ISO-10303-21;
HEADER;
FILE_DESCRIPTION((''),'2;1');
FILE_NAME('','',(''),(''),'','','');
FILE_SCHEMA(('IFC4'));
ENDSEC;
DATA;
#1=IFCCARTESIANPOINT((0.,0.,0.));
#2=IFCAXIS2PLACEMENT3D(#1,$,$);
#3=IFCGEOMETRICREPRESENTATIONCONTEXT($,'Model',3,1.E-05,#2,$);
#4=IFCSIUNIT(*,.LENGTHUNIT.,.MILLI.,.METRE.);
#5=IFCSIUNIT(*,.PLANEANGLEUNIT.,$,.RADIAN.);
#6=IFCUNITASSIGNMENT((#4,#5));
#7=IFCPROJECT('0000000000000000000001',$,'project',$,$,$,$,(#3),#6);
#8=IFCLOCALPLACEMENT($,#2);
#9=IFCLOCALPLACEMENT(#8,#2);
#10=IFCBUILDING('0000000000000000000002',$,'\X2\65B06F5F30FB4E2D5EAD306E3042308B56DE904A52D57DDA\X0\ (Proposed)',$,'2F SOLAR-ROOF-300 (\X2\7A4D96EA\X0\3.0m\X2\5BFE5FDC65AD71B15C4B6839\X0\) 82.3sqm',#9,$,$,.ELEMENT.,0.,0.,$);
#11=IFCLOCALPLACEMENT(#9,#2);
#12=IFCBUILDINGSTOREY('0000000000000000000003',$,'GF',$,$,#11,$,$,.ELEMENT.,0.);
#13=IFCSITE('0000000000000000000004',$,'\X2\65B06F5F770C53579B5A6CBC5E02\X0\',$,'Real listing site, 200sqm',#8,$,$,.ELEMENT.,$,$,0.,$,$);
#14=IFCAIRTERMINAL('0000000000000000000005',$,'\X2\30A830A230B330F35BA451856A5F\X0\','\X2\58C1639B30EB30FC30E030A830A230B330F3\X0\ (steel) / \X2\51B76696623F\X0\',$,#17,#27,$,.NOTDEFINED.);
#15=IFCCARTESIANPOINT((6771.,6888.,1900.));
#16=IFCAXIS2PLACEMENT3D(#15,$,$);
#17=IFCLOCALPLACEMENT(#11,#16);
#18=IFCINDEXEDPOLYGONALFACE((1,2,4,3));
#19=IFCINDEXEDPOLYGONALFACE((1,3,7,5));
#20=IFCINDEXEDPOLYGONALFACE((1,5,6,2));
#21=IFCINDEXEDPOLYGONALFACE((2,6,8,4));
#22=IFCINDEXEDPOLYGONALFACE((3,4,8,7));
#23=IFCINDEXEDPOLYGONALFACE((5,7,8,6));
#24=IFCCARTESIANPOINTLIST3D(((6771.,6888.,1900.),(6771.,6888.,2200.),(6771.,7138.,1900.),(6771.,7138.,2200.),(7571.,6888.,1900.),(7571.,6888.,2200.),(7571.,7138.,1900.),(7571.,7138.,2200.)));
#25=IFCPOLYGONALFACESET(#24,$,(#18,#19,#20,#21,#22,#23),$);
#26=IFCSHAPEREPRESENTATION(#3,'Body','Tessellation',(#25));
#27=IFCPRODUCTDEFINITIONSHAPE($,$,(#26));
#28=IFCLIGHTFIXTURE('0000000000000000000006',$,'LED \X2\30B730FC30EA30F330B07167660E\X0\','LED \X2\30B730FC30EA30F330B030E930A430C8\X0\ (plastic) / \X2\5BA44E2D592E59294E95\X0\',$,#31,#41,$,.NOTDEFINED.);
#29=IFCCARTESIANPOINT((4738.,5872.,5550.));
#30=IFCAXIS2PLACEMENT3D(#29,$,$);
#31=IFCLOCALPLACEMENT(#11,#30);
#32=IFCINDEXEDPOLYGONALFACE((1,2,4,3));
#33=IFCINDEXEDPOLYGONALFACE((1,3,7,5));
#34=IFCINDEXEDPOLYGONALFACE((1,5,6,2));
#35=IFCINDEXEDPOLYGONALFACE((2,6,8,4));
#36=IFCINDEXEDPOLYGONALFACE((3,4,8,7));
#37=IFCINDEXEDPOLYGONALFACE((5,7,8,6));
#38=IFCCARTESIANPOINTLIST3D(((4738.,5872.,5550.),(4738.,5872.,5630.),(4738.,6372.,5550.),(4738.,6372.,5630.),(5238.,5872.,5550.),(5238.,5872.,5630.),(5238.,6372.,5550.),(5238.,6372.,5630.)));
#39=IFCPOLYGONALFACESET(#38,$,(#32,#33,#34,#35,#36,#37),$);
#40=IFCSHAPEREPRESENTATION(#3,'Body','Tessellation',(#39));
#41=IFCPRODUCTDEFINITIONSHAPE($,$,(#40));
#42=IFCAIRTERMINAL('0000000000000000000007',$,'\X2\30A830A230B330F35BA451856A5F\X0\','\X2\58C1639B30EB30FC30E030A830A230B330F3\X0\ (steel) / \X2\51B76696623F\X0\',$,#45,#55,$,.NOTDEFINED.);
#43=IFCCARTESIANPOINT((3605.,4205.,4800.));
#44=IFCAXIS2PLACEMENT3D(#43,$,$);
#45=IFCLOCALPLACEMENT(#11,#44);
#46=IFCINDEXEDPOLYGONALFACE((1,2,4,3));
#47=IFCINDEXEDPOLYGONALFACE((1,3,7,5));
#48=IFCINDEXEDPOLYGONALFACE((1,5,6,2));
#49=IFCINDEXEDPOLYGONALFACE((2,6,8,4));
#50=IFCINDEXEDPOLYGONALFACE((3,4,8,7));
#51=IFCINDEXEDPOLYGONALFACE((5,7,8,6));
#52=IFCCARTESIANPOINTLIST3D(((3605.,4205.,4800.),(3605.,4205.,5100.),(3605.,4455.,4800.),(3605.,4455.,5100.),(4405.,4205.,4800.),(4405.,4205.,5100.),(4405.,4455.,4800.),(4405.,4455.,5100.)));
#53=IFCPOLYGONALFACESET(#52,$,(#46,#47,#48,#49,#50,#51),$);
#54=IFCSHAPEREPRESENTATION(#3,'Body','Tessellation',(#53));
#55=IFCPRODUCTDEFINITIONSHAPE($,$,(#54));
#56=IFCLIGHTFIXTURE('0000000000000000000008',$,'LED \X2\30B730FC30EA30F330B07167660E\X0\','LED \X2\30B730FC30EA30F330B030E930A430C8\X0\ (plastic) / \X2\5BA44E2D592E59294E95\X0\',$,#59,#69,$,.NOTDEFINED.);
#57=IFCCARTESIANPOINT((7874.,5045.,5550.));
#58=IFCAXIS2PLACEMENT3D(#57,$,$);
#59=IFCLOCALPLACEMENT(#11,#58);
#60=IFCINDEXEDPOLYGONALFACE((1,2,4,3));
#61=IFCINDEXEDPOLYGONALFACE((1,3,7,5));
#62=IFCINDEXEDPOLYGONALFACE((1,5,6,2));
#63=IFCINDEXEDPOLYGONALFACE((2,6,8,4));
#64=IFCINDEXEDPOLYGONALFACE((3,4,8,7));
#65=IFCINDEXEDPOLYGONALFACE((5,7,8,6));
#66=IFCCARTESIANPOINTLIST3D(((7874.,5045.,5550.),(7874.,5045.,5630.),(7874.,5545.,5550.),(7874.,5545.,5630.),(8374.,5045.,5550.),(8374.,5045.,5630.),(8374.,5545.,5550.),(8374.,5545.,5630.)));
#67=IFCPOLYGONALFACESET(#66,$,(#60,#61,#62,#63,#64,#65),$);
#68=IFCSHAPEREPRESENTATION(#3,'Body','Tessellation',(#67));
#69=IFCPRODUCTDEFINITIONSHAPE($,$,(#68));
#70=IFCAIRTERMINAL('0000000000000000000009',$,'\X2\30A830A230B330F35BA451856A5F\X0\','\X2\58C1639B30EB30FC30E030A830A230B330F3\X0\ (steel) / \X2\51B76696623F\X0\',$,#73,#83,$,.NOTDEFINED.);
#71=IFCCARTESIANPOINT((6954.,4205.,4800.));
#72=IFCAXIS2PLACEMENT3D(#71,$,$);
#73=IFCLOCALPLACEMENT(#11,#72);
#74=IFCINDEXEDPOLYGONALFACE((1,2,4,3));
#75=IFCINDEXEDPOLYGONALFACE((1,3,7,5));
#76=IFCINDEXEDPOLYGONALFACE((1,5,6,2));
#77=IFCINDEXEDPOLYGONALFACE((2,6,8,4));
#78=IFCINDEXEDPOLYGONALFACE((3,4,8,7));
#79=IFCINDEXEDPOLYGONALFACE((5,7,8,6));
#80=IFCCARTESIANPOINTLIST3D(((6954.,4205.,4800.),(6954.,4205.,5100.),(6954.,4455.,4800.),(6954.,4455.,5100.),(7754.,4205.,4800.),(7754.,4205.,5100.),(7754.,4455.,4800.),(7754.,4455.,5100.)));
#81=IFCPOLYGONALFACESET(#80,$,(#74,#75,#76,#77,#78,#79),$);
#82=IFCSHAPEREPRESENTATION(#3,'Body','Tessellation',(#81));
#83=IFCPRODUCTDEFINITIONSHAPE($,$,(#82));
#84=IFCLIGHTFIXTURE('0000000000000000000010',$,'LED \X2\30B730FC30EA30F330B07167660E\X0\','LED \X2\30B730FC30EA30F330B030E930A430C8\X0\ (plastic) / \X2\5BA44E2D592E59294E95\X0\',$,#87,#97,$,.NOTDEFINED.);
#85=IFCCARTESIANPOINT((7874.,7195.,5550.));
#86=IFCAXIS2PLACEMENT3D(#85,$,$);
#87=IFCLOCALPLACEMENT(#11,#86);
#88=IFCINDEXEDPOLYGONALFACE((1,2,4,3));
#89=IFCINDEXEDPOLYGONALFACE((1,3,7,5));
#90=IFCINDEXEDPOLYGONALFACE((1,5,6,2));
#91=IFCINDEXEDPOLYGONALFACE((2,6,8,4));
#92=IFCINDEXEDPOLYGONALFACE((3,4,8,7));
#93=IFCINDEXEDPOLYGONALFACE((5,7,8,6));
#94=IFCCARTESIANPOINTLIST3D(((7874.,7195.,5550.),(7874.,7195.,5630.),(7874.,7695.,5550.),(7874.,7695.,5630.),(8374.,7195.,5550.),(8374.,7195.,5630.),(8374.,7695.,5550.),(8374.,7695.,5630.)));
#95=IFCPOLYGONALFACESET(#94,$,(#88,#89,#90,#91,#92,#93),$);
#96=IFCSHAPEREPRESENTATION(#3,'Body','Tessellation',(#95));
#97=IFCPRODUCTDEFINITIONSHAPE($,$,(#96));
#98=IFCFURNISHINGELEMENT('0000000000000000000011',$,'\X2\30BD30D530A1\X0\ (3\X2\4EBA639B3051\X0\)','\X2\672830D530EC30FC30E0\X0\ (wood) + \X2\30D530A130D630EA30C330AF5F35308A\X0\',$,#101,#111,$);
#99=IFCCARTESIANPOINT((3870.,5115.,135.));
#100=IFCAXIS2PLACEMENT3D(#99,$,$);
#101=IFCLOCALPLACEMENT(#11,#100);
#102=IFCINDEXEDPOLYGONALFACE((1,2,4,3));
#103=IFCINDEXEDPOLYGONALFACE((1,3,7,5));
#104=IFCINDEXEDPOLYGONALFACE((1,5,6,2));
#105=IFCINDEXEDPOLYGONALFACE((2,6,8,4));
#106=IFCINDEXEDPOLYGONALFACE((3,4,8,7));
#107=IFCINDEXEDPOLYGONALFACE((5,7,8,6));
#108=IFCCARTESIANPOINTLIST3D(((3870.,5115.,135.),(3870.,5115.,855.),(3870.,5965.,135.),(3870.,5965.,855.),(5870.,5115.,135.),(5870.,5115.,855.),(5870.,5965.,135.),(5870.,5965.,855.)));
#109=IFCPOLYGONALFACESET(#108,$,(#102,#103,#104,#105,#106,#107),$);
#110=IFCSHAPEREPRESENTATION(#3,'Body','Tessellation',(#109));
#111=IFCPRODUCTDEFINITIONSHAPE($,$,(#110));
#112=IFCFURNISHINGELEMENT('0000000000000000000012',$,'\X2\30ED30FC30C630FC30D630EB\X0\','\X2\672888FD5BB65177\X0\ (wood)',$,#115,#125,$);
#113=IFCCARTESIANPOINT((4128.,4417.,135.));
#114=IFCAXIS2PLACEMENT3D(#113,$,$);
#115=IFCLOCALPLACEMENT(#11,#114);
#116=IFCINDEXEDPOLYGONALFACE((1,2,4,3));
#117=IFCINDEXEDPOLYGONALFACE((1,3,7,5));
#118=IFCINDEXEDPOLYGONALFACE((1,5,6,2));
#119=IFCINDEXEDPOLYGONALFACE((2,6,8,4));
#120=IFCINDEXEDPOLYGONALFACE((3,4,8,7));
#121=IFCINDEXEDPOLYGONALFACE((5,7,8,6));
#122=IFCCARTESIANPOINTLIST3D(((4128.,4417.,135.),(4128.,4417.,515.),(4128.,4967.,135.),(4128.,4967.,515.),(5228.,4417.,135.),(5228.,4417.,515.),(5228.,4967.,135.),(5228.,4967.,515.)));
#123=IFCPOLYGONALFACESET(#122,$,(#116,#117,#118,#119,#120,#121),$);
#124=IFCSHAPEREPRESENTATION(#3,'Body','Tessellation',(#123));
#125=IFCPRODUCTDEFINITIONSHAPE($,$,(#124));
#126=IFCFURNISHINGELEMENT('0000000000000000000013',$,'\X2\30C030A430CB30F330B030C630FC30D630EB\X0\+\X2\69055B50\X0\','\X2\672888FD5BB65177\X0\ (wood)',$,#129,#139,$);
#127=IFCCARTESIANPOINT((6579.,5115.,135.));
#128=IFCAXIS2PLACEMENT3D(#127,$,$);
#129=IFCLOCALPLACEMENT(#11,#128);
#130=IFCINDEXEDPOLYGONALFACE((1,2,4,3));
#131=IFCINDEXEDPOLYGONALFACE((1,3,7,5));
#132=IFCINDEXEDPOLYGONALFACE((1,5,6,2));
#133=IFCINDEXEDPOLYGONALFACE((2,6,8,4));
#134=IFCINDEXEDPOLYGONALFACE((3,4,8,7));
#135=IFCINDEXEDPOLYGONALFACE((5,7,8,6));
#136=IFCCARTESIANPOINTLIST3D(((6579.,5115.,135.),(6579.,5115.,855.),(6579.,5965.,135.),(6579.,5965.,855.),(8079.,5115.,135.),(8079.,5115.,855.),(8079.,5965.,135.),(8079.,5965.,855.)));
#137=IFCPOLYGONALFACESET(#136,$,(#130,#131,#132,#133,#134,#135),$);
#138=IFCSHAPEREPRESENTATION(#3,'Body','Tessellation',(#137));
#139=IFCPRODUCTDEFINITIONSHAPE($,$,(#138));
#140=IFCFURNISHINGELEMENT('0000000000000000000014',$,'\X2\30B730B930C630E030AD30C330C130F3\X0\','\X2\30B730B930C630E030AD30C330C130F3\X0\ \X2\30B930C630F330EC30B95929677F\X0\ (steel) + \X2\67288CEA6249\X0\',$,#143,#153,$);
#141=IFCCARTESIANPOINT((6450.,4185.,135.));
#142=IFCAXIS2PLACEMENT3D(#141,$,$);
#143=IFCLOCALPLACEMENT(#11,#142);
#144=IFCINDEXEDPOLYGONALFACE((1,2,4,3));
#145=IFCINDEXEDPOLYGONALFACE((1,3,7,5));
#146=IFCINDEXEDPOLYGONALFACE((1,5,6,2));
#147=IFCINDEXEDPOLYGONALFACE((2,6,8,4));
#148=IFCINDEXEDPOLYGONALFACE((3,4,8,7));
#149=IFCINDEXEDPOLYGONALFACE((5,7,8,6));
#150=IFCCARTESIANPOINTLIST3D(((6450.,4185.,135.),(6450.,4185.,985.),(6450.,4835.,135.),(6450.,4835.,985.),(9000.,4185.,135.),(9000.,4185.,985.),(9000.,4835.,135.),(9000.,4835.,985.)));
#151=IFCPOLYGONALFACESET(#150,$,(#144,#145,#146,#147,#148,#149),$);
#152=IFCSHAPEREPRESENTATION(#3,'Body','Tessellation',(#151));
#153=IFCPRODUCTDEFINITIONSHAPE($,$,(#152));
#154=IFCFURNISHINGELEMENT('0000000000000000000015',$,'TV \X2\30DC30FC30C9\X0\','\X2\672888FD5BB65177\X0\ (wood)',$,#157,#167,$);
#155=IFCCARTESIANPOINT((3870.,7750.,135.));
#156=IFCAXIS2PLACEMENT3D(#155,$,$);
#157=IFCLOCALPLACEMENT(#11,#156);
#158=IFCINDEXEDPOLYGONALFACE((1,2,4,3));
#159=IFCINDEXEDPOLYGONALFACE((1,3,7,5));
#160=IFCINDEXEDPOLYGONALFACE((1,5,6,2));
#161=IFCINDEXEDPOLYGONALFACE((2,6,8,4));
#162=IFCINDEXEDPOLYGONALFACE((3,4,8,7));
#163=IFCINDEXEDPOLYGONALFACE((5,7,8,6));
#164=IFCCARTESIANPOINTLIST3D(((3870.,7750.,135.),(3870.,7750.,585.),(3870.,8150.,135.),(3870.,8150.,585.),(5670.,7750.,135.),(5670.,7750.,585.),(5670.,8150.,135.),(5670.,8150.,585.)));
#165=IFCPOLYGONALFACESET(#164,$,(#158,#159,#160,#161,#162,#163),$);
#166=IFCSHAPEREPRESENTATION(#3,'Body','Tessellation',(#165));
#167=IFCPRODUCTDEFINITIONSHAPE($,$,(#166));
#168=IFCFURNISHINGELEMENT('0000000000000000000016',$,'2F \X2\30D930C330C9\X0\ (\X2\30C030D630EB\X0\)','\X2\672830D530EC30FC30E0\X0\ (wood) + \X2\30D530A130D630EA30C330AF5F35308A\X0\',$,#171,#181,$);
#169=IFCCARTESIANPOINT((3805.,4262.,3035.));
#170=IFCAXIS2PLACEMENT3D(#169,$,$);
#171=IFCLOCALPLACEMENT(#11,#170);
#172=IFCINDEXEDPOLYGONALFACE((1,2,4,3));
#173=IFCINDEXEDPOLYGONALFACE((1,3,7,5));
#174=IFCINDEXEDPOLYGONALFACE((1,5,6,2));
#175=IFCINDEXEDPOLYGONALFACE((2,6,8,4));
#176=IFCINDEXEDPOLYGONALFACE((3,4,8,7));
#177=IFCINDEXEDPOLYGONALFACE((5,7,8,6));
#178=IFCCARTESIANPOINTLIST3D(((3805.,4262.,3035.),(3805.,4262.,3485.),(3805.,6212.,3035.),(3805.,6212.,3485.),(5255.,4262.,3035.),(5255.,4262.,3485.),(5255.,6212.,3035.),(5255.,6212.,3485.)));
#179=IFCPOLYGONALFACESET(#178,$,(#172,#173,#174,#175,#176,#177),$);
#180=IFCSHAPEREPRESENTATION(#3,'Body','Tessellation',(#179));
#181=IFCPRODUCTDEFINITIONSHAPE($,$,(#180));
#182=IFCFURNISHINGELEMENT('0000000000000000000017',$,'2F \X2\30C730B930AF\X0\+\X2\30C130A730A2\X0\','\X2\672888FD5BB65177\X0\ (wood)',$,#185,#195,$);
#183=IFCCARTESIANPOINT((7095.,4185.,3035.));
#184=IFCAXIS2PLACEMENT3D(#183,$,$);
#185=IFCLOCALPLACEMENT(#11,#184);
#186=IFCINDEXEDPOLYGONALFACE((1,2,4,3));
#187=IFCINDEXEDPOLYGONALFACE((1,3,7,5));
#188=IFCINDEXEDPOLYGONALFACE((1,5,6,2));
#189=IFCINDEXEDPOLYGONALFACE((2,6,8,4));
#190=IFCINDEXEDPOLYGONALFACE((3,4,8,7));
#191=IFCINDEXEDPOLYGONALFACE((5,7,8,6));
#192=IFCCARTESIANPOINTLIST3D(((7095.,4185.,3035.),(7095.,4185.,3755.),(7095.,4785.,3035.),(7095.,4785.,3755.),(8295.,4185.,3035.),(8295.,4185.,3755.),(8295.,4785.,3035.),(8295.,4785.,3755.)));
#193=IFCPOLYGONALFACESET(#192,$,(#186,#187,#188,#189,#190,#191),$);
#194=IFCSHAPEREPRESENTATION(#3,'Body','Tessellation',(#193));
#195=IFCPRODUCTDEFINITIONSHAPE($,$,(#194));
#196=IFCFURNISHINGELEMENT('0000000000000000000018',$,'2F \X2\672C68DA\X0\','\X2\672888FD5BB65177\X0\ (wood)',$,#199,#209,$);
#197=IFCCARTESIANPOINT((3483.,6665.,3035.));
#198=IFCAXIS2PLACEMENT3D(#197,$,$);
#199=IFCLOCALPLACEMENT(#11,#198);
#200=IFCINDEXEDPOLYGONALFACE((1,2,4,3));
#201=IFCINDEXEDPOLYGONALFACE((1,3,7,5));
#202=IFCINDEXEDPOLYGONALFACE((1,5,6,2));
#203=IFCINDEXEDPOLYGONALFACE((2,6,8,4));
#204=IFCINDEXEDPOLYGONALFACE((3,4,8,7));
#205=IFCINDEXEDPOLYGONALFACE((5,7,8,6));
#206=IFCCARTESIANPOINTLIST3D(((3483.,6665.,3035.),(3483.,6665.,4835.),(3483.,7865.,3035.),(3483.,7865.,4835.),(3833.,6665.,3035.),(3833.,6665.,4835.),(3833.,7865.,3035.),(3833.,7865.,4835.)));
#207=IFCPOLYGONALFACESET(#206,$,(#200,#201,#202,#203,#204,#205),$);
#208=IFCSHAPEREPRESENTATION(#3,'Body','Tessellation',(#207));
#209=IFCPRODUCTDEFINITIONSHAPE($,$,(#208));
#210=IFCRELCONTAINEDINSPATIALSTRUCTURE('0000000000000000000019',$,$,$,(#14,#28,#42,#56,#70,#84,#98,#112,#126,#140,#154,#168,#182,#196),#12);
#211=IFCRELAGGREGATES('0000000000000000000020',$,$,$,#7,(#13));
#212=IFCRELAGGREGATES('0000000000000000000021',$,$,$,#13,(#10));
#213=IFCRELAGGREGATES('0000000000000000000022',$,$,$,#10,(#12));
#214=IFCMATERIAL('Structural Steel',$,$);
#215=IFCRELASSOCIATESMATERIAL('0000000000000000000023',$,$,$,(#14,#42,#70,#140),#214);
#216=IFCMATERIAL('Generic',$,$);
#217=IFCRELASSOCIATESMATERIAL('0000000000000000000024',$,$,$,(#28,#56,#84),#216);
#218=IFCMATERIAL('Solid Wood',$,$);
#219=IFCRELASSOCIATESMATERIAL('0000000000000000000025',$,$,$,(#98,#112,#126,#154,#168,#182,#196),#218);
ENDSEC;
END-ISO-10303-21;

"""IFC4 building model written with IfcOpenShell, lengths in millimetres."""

from ifc_helpers import new_model, si_unit, frame, frame_2d, origin, place, context, project, spatial, rectangle, extrude, material, element, save


model = new_model("IFC4")

# Units and contexts
model_context = context("Model", 3, precision=1e-05, world=origin())
ifc_project = project(units=[si_unit("LENGTHUNIT", "METRE", prefix="MILLI"), si_unit("PLANEANGLEUNIT", "RADIAN")], contexts=[model_context])

# Site, building, storey
site_placement = place(None, origin())
site = spatial("IfcSite", under=ifc_project, at=site_placement, Name="新潟県南魚沼市", ObjectType="Real listing site, 200sqm", CompositionType="ELEMENT", RefElevation=0.0)
building_placement = place(site_placement, origin())
building = spatial("IfcBuilding", under=site, at=building_placement, Name="新潟・中庭のある回遊動線 (Proposed)", ObjectType="2F SOLAR-ROOF-300 (積雪3.0m対応断熱屋根) 82.3sqm", CompositionType="ELEMENT", ElevationOfRefHeight=0.0, ElevationOfTerrain=0.0)
storey_placement = place(building_placement, origin())
storey = spatial("IfcBuildingStorey", under=building, at=storey_placement, Name="GF", CompositionType="ELEMENT", Elevation=0.0)

# Shared definitions
ifc_material_1 = material(Name="Solid Wood")

# Shared definitions
ifc_material_2 = material(Name="Structural Steel")

# Shared definitions
ifc_material_3 = material(Name="Generic")

# Air terminal
air_terminal_1_placement = place(storey_placement, frame((6771.0, 6888.0, 1900.0)))
element("IfcAirTerminal", 1, at=air_terminal_1_placement, inside=storey, material=ifc_material_2, Name="エアコン室内機", Description="壁掛ルームエアコン (steel) / 冷暖房", PredefinedType="NOTDEFINED", context=model_context, shape_type="SweptSolid", body=[
    extrude(rectangle(XDim=800.0, YDim=250.0, at=frame_2d((400.0, 125.0))), frame((6771.0, 6888.0, 1900.0)), (0.0, 0.0, 1.0), 300.0),
])

# Light fixture
light_fixture_1_placement = place(storey_placement, frame((4738.0, 5872.0, 5550.0)))
element("IfcLightFixture", 2, at=light_fixture_1_placement, inside=storey, material=ifc_material_3, Name="LED シーリング照明", Description="LED シーリングライト (plastic) / 室中央天井", PredefinedType="NOTDEFINED", context=model_context, shape_type="SweptSolid", body=[
    extrude(rectangle(XDim=500.0, YDim=500.0, at=frame_2d((250.0, 250.0))), frame((4738.0, 5872.0, 5550.0)), (0.0, 0.0, 1.0), 80.0),
])

# Air terminal
air_terminal_2_placement = place(storey_placement, frame((3605.0, 4205.0, 4800.0)))
element("IfcAirTerminal", 3, at=air_terminal_2_placement, inside=storey, material=ifc_material_2, Name="エアコン室内機", Description="壁掛ルームエアコン (steel) / 冷暖房", PredefinedType="NOTDEFINED", context=model_context, shape_type="SweptSolid", body=[
    extrude(rectangle(XDim=800.0, YDim=250.0, at=frame_2d((400.0, 125.0))), frame((3605.0, 4205.0, 4800.0)), (0.0, 0.0, 1.0), 300.0),
])

# Light fixture
light_fixture_2_placement = place(storey_placement, frame((7874.0, 5045.0, 5550.0)))
element("IfcLightFixture", 4, at=light_fixture_2_placement, inside=storey, material=ifc_material_3, Name="LED シーリング照明", Description="LED シーリングライト (plastic) / 室中央天井", PredefinedType="NOTDEFINED", context=model_context, shape_type="SweptSolid", body=[
    extrude(rectangle(XDim=500.0, YDim=500.0, at=frame_2d((250.0, 250.0))), frame((7874.0, 5045.0, 5550.0)), (0.0, 0.0, 1.0), 80.0),
])

# Air terminal
air_terminal_3_placement = place(storey_placement, frame((6954.0, 4205.0, 4800.0)))
element("IfcAirTerminal", 5, at=air_terminal_3_placement, inside=storey, material=ifc_material_2, Name="エアコン室内機", Description="壁掛ルームエアコン (steel) / 冷暖房", PredefinedType="NOTDEFINED", context=model_context, shape_type="SweptSolid", body=[
    extrude(rectangle(XDim=800.0, YDim=250.0, at=frame_2d((400.0, 125.0))), frame((6954.0, 4205.0, 4800.0)), (0.0, 0.0, 1.0), 300.0),
])

# Light fixture
light_fixture_3_placement = place(storey_placement, frame((7874.0, 7195.0, 5550.0)))
element("IfcLightFixture", 6, at=light_fixture_3_placement, inside=storey, material=ifc_material_3, Name="LED シーリング照明", Description="LED シーリングライト (plastic) / 室中央天井", PredefinedType="NOTDEFINED", context=model_context, shape_type="SweptSolid", body=[
    extrude(rectangle(XDim=500.0, YDim=500.0, at=frame_2d((250.0, 250.0))), frame((7874.0, 7195.0, 5550.0)), (0.0, 0.0, 1.0), 80.0),
])

# Furnishing elements
furnishing_1_placement = place(storey_placement, frame((3870.0, 5115.0, 135.0)))
element("IfcFurnishingElement", 7, at=furnishing_1_placement, inside=storey, material=ifc_material_1, Name="ソファ (3人掛け)", Description="木フレーム (wood) + ファブリック張り", context=model_context, shape_type="SweptSolid", body=[
    extrude(rectangle(XDim=2000.0, YDim=850.0, at=frame_2d((1000.0, 425.0))), frame((3870.0, 5115.0, 135.0)), (0.0, 0.0, 1.0), 720.0),
])
furnishing_2_placement = place(storey_placement, frame((4128.0, 4417.0, 135.0)))
element("IfcFurnishingElement", 8, at=furnishing_2_placement, inside=storey, material=ifc_material_1, Name="ローテーブル", Description="木製家具 (wood)", context=model_context, shape_type="SweptSolid", body=[
    extrude(rectangle(XDim=1100.0, YDim=550.0, at=frame_2d((550.0, 275.0))), frame((4128.0, 4417.0, 135.0)), (0.0, 0.0, 1.0), 380.0),
])
furnishing_3_placement = place(storey_placement, frame((6579.0, 5115.0, 135.0)))
element("IfcFurnishingElement", 9, at=furnishing_3_placement, inside=storey, material=ifc_material_1, Name="ダイニングテーブル+椅子", Description="木製家具 (wood)", context=model_context, shape_type="SweptSolid", body=[
    extrude(rectangle(XDim=1500.0, YDim=850.0, at=frame_2d((750.0, 425.0))), frame((6579.0, 5115.0, 135.0)), (0.0, 0.0, 1.0), 720.0),
])
furnishing_4_placement = place(storey_placement, frame((6450.0, 4185.0, 135.0)))
element("IfcFurnishingElement", 10, at=furnishing_4_placement, inside=storey, material=ifc_material_2, Name="システムキッチン", Description="システムキッチン ステンレス天板 (steel) + 木質扉", context=model_context, shape_type="SweptSolid", body=[
    extrude(rectangle(XDim=2550.0, YDim=650.0, at=frame_2d((1275.0, 325.0))), frame((6450.0, 4185.0, 135.0)), (0.0, 0.0, 1.0), 850.0),
])
furnishing_5_placement = place(storey_placement, frame((3870.0, 7750.0, 135.0)))
element("IfcFurnishingElement", 11, at=furnishing_5_placement, inside=storey, material=ifc_material_1, Name="TV ボード", Description="木製家具 (wood)", context=model_context, shape_type="SweptSolid", body=[
    extrude(rectangle(XDim=1800.0, YDim=400.0, at=frame_2d((900.0, 200.0))), frame((3870.0, 7750.0, 135.0)), (0.0, 0.0, 1.0), 450.0),
])
furnishing_6_placement = place(storey_placement, frame((3805.0, 4262.0, 3035.0)))
element("IfcFurnishingElement", 12, at=furnishing_6_placement, inside=storey, material=ifc_material_1, Name="2F ベッド (ダブル)", Description="木フレーム (wood) + ファブリック張り", context=model_context, shape_type="SweptSolid", body=[
    extrude(rectangle(XDim=1450.0, YDim=1950.0, at=frame_2d((725.0, 975.0))), frame((3805.0, 4262.0, 3035.0)), (0.0, 0.0, 1.0), 450.0),
])
furnishing_7_placement = place(storey_placement, frame((7095.0, 4185.0, 3035.0)))
element("IfcFurnishingElement", 13, at=furnishing_7_placement, inside=storey, material=ifc_material_1, Name="2F デスク+チェア", Description="木製家具 (wood)", context=model_context, shape_type="SweptSolid", body=[
    extrude(rectangle(XDim=1200.0, YDim=600.0, at=frame_2d((600.0, 300.0))), frame((7095.0, 4185.0, 3035.0)), (0.0, 0.0, 1.0), 720.0),
])
furnishing_8_placement = place(storey_placement, frame((3483.0, 6665.0, 3035.0)))
element("IfcFurnishingElement", 14, at=furnishing_8_placement, inside=storey, material=ifc_material_1, Name="2F 本棚", Description="木製家具 (wood)", context=model_context, shape_type="SweptSolid", body=[
    extrude(rectangle(XDim=350.0, YDim=1200.0, at=frame_2d((175.0, 600.0))), frame((3483.0, 6665.0, 3035.0)), (0.0, 0.0, 1.0), 1800.0),
])

save(model, "model.ifc")
